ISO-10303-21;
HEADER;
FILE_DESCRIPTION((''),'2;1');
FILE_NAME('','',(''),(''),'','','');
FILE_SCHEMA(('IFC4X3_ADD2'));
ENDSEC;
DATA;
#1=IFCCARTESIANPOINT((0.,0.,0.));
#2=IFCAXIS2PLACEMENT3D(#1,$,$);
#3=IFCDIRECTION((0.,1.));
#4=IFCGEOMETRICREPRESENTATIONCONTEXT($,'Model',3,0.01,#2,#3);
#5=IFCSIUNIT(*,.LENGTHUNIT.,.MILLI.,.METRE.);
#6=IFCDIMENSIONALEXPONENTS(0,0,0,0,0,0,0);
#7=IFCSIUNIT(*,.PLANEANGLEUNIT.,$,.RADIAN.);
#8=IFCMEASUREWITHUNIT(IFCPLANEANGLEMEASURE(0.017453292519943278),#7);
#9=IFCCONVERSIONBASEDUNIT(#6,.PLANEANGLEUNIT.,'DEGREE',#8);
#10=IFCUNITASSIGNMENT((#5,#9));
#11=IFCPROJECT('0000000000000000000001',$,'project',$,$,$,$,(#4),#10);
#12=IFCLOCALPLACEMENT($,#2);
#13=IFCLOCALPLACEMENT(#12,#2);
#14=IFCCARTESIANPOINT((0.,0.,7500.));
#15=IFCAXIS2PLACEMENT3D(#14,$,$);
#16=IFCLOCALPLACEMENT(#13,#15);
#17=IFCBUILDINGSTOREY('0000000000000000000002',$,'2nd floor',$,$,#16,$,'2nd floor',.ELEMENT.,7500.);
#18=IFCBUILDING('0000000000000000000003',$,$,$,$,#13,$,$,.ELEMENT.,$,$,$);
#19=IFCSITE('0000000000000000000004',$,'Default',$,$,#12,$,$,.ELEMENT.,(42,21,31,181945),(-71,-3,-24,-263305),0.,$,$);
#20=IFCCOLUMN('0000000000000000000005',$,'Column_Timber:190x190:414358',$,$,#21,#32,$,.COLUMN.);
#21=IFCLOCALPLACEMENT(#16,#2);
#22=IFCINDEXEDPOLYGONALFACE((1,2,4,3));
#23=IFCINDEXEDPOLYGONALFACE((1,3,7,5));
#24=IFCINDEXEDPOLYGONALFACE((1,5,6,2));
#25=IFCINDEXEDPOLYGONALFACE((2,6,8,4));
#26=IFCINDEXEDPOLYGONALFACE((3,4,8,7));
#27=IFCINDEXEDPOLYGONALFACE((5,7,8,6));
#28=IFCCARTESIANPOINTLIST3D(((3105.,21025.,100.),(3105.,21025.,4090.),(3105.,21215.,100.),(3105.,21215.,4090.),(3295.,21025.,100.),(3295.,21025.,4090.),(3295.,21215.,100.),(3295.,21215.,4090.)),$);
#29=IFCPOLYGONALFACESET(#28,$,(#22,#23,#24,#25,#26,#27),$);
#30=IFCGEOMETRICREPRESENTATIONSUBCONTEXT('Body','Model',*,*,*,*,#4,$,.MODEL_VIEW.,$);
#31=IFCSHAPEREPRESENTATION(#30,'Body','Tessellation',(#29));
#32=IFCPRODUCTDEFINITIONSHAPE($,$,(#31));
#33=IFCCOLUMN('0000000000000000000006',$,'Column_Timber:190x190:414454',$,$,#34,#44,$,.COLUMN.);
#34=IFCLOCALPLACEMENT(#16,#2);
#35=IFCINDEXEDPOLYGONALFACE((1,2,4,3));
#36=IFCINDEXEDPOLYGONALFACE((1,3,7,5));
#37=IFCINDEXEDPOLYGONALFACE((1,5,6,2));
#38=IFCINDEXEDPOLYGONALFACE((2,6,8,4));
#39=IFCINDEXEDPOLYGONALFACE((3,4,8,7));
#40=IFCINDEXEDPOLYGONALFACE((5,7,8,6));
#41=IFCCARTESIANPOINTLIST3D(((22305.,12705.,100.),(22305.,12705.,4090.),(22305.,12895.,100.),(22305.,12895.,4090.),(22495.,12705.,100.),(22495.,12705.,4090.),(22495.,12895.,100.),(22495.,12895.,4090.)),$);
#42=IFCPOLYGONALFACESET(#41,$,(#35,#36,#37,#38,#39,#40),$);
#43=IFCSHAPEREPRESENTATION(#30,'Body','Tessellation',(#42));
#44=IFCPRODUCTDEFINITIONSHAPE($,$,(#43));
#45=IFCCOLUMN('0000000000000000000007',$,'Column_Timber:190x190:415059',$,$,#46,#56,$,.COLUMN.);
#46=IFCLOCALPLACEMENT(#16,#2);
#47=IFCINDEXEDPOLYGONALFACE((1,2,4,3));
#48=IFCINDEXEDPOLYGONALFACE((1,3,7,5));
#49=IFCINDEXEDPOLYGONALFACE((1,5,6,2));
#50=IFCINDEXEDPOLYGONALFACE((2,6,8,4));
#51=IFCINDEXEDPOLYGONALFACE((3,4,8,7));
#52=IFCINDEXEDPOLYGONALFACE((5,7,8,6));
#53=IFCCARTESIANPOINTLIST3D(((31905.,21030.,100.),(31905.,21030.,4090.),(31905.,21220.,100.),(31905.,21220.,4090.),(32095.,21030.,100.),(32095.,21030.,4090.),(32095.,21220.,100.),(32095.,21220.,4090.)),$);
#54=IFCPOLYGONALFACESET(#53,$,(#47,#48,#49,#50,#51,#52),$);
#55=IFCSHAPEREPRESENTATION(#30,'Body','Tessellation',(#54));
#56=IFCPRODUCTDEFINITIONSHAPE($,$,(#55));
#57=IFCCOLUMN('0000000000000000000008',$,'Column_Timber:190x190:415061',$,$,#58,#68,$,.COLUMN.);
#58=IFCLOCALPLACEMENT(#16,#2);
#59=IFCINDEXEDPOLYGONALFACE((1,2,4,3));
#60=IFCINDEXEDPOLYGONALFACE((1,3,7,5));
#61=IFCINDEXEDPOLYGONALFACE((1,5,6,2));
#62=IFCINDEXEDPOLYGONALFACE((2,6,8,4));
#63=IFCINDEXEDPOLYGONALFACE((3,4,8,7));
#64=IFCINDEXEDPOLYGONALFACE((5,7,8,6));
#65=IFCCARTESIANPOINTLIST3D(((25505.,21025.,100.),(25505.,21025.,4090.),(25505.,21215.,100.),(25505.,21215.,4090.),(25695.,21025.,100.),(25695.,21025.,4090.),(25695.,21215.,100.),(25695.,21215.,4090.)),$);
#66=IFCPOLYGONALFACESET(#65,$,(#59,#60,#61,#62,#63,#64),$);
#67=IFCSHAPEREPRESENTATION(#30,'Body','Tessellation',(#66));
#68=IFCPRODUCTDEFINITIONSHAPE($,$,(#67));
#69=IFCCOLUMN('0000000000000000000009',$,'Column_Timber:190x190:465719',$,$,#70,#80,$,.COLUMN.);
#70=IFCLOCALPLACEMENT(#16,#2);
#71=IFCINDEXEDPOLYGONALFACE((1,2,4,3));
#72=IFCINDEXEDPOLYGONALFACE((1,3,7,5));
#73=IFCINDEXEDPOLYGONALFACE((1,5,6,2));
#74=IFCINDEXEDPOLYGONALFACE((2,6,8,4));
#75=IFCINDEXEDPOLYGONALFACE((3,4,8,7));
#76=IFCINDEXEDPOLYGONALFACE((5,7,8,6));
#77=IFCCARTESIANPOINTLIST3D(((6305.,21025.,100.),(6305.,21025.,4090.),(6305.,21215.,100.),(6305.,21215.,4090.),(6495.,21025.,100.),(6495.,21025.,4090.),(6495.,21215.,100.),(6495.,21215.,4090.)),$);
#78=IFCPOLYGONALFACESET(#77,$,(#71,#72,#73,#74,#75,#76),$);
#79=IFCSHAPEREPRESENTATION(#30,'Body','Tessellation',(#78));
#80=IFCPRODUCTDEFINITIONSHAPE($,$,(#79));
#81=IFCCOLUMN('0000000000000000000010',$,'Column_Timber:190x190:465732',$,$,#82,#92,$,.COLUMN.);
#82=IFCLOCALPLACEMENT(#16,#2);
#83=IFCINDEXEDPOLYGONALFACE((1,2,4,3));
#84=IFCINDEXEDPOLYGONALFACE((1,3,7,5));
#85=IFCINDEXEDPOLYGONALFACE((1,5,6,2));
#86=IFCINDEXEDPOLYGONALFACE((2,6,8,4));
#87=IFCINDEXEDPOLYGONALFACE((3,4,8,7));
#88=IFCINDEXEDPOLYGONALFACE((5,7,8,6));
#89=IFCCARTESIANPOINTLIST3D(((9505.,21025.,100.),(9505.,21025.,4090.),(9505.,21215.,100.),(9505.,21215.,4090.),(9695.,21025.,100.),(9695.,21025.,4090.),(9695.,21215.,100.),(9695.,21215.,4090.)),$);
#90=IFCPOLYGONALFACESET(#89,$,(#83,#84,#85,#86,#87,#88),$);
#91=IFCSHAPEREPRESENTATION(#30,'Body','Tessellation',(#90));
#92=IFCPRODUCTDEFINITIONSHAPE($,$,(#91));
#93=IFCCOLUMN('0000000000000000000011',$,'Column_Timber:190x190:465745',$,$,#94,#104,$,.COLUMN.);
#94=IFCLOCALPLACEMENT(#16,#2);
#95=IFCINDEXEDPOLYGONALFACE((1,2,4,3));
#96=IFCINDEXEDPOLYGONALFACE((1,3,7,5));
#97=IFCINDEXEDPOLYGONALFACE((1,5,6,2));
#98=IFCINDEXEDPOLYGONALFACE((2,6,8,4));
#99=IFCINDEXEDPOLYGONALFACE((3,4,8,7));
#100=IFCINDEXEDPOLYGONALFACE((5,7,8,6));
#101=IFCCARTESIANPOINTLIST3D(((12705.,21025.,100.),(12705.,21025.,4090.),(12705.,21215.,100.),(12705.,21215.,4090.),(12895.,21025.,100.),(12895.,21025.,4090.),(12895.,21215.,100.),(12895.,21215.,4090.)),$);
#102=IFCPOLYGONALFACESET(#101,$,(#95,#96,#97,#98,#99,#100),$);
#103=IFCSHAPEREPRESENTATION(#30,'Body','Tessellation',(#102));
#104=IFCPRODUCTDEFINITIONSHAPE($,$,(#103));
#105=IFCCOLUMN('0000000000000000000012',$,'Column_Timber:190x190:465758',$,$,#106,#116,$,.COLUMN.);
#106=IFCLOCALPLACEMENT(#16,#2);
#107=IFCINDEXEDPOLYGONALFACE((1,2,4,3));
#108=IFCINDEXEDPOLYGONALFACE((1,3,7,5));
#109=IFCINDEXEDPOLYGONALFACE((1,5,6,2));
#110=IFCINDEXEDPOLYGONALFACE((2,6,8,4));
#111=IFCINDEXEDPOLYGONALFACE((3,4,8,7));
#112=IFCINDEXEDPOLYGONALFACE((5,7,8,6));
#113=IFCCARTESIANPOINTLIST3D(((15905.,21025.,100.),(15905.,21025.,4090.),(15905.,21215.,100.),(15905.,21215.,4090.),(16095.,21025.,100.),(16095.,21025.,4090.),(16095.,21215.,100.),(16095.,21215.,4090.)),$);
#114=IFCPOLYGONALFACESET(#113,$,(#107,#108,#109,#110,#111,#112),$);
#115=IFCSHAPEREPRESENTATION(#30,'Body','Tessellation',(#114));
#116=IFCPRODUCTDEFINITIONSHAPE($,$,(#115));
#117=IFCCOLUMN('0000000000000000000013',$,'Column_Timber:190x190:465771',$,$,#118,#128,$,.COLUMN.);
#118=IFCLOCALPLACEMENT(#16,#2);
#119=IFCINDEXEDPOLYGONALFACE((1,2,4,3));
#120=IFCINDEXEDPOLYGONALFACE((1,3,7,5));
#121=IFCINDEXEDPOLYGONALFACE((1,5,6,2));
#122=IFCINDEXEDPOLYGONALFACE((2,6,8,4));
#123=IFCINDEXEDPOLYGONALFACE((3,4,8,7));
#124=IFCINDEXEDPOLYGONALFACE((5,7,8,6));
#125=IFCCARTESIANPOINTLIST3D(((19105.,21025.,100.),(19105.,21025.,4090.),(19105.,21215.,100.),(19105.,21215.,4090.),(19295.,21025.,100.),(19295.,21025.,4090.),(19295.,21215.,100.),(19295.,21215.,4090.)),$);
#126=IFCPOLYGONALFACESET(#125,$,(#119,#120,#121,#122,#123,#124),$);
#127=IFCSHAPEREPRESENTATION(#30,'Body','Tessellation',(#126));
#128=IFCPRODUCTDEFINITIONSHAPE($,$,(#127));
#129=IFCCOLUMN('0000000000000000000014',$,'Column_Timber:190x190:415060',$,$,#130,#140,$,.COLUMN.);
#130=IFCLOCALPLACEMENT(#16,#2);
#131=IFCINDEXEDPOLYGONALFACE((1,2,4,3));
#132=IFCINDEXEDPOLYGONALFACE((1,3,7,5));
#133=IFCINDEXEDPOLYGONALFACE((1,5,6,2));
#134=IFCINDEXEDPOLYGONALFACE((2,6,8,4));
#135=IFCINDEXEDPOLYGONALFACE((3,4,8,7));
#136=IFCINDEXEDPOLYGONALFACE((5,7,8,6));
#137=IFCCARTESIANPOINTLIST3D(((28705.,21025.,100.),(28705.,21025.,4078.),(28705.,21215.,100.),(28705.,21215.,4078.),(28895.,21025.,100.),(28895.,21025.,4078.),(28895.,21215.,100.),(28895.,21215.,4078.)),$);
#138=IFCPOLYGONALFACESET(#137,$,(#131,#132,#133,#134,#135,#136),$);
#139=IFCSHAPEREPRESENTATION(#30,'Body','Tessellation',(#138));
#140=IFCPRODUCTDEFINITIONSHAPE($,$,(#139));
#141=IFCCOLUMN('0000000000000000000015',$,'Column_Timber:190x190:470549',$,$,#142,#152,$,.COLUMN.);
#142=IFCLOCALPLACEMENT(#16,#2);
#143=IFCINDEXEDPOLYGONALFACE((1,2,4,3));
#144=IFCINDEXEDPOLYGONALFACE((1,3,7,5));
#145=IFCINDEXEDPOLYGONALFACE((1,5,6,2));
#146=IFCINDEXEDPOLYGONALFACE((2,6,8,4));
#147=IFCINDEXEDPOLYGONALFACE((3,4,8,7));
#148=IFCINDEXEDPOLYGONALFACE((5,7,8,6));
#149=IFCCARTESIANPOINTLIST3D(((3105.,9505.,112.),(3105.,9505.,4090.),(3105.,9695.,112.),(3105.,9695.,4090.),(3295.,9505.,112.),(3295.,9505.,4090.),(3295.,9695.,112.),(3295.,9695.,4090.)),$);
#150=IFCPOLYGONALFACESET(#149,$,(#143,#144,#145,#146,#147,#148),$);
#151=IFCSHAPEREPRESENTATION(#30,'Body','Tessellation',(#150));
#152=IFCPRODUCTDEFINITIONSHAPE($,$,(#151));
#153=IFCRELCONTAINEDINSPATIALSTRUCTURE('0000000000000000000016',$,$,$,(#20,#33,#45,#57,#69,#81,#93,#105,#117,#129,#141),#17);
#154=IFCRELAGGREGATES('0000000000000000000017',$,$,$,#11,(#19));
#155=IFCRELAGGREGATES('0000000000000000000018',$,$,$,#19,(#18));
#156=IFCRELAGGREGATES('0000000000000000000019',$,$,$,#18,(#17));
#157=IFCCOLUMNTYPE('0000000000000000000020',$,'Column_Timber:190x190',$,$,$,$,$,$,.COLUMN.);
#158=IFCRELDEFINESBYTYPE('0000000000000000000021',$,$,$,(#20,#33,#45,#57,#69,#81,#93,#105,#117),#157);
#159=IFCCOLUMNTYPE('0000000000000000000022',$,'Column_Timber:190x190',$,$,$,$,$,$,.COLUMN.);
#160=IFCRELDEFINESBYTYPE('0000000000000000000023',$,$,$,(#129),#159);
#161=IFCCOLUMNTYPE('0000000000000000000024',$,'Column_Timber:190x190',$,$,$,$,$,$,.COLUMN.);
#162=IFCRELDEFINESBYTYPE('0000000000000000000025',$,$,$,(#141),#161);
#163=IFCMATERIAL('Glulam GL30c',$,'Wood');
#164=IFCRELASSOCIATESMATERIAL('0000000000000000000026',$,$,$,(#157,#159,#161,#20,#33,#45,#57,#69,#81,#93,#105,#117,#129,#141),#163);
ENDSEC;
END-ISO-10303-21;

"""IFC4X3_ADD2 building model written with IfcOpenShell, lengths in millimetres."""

from ifc_helpers import new_model, entity, si_unit, converted_unit, direction, frame, origin, origin_2d_with_axis, place, context, subcontext, project, spatial, rectangle, extrude, source, transform, mapped, material, material_profile, profile_set, profile_usage, type_object, type_shapes, element, save


model = new_model("IFC4X3_ADD2")

# Units and contexts
model_context = context("Model", 3, precision=0.01, world=origin(), true_north=direction((0.0, 1.0)))
body_context = subcontext(model_context, "Body", "Model", "MODEL_VIEW")
ifc_project = project(units=[si_unit("LENGTHUNIT", "METRE", prefix="MILLI"), converted_unit("PLANEANGLEUNIT", "DEGREE", entity("IfcPlaneAngleMeasure", 0.017453292519943278), si_unit("PLANEANGLEUNIT", "RADIAN"), dimensions=[0, 0, 0, 0, 0, 0, 0])], contexts=[model_context])

# Site, building, storey
site_placement = place(None, origin())
site = spatial("IfcSite", under=ifc_project, at=site_placement, Name="Default", CompositionType="ELEMENT", RefLatitude=(42, 21, 31, 181945), RefLongitude=(-71, -3, -24, -263305), RefElevation=0.0)
building_placement = place(site_placement, origin())
building = spatial("IfcBuilding", under=site, at=building_placement, CompositionType="ELEMENT")
storey_placement = place(building_placement, frame((0.0, 0.0, 7500.0)))
storey = spatial("IfcBuildingStorey", under=building, at=storey_placement, Name="2nd floor", LongName="2nd floor", CompositionType="ELEMENT", Elevation=7500.0)

# Columns
ifc_material_1 = material(Name="Glulam GL30c", Category="Wood")
ifc_material_profile_1 = material_profile(ifc_material_1, rectangle(XDim=190.0, YDim=190.0, at=origin_2d_with_axis()), Name="190x190")
ifc_profile_set_1 = profile_set([ifc_material_profile_1], Name="190x190")
ifc_profile_usage_1 = profile_usage(ifc_profile_set_1)
column_type_1 = type_object("IfcColumnType", Name="Column_Timber:190x190", PredefinedType="COLUMN", material=ifc_profile_set_1)
shared_shape_1 = source(origin(), body_context, "Body", "SweptSolid", [
    extrude(rectangle(XDim=190.0, YDim=190.0, at=origin_2d_with_axis()), frame((0.0, 0.0, 7600.0), z_axis=(0.0, 0.0, 1.0), x_axis=(-1.0, 0.0, 0.0)), (0.0, 0.0, 1.0), 3990.0),
])
type_shapes(column_type_1, [shared_shape_1])
for number, where, name in (
    (1, (3200.0, 21120.0, -7500.0), "Column_Timber:190x190:414358"),
    (2, (22400.0, 12800.0, -7500.0), "Column_Timber:190x190:414454"),
    (3, (32000.0, 21125.0, -7500.0), "Column_Timber:190x190:415059"),
    (4, (25600.0, 21120.0, -7500.0), "Column_Timber:190x190:415061"),
    (5, (6400.0, 21120.0, -7500.0), "Column_Timber:190x190:465719"),
    (6, (9600.0, 21120.0, -7500.0), "Column_Timber:190x190:465732"),
    (7, (12800.0, 21120.0, -7500.0), "Column_Timber:190x190:465745"),
    (8, (16000.0, 21120.0, -7500.0), "Column_Timber:190x190:465758"),
    (9, (19200.0, 21120.0, -7500.0), "Column_Timber:190x190:465771"),
):
    element("IfcColumn", number, at=place(storey_placement, frame(where)), inside=storey, type_object=column_type_1, material=ifc_profile_usage_1, Name=name, PredefinedType="COLUMN", context=body_context, shape_type="MappedRepresentation", body=[
        mapped(shared_shape_1, transform((0.0, 0.0, 0.0), scale=1.0)),
    ])
column_type_2 = type_object("IfcColumnType", Name="Column_Timber:190x190", PredefinedType="COLUMN", material=ifc_profile_set_1)
shared_shape_2 = source(origin(), body_context, "Body", "SweptSolid", [
    extrude(rectangle(XDim=190.0, YDim=190.0, at=origin_2d_with_axis()), frame((0.0, 0.0, 7600.0), z_axis=(0.0, 0.0, 1.0), x_axis=(-1.0, 0.0, 0.0)), (0.0, 0.0, 1.0), 3978.0),
])
type_shapes(column_type_2, [shared_shape_2])
column_1_placement = place(storey_placement, frame((28800.0, 21120.0, -7500.0)))
element("IfcColumn", 10, at=column_1_placement, inside=storey, type_object=column_type_2, material=ifc_profile_usage_1, Name="Column_Timber:190x190:415060", PredefinedType="COLUMN", context=body_context, shape_type="MappedRepresentation", body=[
    mapped(shared_shape_2, transform((0.0, 0.0, 0.0), scale=1.0)),
])
column_type_3 = type_object("IfcColumnType", Name="Column_Timber:190x190", PredefinedType="COLUMN", material=ifc_profile_set_1)
shared_shape_3 = source(origin(), body_context, "Body", "SweptSolid", [
    extrude(rectangle(XDim=190.0, YDim=190.0, at=origin_2d_with_axis()), frame((0.0, 0.0, 7612.0), z_axis=(0.0, 0.0, 1.0), x_axis=(-1.0, 0.0, 0.0)), (0.0, 0.0, 1.0), 3978.0),
])
type_shapes(column_type_3, [shared_shape_3])
column_2_placement = place(storey_placement, frame((3200.0, 9600.0, -7500.0)))
element("IfcColumn", 11, at=column_2_placement, inside=storey, type_object=column_type_3, material=ifc_profile_usage_1, Name="Column_Timber:190x190:470549", PredefinedType="COLUMN", context=body_context, shape_type="MappedRepresentation", body=[
    mapped(shared_shape_3, transform((0.0, 0.0, 0.0), scale=1.0)),
])

save(model, "model.ifc")
